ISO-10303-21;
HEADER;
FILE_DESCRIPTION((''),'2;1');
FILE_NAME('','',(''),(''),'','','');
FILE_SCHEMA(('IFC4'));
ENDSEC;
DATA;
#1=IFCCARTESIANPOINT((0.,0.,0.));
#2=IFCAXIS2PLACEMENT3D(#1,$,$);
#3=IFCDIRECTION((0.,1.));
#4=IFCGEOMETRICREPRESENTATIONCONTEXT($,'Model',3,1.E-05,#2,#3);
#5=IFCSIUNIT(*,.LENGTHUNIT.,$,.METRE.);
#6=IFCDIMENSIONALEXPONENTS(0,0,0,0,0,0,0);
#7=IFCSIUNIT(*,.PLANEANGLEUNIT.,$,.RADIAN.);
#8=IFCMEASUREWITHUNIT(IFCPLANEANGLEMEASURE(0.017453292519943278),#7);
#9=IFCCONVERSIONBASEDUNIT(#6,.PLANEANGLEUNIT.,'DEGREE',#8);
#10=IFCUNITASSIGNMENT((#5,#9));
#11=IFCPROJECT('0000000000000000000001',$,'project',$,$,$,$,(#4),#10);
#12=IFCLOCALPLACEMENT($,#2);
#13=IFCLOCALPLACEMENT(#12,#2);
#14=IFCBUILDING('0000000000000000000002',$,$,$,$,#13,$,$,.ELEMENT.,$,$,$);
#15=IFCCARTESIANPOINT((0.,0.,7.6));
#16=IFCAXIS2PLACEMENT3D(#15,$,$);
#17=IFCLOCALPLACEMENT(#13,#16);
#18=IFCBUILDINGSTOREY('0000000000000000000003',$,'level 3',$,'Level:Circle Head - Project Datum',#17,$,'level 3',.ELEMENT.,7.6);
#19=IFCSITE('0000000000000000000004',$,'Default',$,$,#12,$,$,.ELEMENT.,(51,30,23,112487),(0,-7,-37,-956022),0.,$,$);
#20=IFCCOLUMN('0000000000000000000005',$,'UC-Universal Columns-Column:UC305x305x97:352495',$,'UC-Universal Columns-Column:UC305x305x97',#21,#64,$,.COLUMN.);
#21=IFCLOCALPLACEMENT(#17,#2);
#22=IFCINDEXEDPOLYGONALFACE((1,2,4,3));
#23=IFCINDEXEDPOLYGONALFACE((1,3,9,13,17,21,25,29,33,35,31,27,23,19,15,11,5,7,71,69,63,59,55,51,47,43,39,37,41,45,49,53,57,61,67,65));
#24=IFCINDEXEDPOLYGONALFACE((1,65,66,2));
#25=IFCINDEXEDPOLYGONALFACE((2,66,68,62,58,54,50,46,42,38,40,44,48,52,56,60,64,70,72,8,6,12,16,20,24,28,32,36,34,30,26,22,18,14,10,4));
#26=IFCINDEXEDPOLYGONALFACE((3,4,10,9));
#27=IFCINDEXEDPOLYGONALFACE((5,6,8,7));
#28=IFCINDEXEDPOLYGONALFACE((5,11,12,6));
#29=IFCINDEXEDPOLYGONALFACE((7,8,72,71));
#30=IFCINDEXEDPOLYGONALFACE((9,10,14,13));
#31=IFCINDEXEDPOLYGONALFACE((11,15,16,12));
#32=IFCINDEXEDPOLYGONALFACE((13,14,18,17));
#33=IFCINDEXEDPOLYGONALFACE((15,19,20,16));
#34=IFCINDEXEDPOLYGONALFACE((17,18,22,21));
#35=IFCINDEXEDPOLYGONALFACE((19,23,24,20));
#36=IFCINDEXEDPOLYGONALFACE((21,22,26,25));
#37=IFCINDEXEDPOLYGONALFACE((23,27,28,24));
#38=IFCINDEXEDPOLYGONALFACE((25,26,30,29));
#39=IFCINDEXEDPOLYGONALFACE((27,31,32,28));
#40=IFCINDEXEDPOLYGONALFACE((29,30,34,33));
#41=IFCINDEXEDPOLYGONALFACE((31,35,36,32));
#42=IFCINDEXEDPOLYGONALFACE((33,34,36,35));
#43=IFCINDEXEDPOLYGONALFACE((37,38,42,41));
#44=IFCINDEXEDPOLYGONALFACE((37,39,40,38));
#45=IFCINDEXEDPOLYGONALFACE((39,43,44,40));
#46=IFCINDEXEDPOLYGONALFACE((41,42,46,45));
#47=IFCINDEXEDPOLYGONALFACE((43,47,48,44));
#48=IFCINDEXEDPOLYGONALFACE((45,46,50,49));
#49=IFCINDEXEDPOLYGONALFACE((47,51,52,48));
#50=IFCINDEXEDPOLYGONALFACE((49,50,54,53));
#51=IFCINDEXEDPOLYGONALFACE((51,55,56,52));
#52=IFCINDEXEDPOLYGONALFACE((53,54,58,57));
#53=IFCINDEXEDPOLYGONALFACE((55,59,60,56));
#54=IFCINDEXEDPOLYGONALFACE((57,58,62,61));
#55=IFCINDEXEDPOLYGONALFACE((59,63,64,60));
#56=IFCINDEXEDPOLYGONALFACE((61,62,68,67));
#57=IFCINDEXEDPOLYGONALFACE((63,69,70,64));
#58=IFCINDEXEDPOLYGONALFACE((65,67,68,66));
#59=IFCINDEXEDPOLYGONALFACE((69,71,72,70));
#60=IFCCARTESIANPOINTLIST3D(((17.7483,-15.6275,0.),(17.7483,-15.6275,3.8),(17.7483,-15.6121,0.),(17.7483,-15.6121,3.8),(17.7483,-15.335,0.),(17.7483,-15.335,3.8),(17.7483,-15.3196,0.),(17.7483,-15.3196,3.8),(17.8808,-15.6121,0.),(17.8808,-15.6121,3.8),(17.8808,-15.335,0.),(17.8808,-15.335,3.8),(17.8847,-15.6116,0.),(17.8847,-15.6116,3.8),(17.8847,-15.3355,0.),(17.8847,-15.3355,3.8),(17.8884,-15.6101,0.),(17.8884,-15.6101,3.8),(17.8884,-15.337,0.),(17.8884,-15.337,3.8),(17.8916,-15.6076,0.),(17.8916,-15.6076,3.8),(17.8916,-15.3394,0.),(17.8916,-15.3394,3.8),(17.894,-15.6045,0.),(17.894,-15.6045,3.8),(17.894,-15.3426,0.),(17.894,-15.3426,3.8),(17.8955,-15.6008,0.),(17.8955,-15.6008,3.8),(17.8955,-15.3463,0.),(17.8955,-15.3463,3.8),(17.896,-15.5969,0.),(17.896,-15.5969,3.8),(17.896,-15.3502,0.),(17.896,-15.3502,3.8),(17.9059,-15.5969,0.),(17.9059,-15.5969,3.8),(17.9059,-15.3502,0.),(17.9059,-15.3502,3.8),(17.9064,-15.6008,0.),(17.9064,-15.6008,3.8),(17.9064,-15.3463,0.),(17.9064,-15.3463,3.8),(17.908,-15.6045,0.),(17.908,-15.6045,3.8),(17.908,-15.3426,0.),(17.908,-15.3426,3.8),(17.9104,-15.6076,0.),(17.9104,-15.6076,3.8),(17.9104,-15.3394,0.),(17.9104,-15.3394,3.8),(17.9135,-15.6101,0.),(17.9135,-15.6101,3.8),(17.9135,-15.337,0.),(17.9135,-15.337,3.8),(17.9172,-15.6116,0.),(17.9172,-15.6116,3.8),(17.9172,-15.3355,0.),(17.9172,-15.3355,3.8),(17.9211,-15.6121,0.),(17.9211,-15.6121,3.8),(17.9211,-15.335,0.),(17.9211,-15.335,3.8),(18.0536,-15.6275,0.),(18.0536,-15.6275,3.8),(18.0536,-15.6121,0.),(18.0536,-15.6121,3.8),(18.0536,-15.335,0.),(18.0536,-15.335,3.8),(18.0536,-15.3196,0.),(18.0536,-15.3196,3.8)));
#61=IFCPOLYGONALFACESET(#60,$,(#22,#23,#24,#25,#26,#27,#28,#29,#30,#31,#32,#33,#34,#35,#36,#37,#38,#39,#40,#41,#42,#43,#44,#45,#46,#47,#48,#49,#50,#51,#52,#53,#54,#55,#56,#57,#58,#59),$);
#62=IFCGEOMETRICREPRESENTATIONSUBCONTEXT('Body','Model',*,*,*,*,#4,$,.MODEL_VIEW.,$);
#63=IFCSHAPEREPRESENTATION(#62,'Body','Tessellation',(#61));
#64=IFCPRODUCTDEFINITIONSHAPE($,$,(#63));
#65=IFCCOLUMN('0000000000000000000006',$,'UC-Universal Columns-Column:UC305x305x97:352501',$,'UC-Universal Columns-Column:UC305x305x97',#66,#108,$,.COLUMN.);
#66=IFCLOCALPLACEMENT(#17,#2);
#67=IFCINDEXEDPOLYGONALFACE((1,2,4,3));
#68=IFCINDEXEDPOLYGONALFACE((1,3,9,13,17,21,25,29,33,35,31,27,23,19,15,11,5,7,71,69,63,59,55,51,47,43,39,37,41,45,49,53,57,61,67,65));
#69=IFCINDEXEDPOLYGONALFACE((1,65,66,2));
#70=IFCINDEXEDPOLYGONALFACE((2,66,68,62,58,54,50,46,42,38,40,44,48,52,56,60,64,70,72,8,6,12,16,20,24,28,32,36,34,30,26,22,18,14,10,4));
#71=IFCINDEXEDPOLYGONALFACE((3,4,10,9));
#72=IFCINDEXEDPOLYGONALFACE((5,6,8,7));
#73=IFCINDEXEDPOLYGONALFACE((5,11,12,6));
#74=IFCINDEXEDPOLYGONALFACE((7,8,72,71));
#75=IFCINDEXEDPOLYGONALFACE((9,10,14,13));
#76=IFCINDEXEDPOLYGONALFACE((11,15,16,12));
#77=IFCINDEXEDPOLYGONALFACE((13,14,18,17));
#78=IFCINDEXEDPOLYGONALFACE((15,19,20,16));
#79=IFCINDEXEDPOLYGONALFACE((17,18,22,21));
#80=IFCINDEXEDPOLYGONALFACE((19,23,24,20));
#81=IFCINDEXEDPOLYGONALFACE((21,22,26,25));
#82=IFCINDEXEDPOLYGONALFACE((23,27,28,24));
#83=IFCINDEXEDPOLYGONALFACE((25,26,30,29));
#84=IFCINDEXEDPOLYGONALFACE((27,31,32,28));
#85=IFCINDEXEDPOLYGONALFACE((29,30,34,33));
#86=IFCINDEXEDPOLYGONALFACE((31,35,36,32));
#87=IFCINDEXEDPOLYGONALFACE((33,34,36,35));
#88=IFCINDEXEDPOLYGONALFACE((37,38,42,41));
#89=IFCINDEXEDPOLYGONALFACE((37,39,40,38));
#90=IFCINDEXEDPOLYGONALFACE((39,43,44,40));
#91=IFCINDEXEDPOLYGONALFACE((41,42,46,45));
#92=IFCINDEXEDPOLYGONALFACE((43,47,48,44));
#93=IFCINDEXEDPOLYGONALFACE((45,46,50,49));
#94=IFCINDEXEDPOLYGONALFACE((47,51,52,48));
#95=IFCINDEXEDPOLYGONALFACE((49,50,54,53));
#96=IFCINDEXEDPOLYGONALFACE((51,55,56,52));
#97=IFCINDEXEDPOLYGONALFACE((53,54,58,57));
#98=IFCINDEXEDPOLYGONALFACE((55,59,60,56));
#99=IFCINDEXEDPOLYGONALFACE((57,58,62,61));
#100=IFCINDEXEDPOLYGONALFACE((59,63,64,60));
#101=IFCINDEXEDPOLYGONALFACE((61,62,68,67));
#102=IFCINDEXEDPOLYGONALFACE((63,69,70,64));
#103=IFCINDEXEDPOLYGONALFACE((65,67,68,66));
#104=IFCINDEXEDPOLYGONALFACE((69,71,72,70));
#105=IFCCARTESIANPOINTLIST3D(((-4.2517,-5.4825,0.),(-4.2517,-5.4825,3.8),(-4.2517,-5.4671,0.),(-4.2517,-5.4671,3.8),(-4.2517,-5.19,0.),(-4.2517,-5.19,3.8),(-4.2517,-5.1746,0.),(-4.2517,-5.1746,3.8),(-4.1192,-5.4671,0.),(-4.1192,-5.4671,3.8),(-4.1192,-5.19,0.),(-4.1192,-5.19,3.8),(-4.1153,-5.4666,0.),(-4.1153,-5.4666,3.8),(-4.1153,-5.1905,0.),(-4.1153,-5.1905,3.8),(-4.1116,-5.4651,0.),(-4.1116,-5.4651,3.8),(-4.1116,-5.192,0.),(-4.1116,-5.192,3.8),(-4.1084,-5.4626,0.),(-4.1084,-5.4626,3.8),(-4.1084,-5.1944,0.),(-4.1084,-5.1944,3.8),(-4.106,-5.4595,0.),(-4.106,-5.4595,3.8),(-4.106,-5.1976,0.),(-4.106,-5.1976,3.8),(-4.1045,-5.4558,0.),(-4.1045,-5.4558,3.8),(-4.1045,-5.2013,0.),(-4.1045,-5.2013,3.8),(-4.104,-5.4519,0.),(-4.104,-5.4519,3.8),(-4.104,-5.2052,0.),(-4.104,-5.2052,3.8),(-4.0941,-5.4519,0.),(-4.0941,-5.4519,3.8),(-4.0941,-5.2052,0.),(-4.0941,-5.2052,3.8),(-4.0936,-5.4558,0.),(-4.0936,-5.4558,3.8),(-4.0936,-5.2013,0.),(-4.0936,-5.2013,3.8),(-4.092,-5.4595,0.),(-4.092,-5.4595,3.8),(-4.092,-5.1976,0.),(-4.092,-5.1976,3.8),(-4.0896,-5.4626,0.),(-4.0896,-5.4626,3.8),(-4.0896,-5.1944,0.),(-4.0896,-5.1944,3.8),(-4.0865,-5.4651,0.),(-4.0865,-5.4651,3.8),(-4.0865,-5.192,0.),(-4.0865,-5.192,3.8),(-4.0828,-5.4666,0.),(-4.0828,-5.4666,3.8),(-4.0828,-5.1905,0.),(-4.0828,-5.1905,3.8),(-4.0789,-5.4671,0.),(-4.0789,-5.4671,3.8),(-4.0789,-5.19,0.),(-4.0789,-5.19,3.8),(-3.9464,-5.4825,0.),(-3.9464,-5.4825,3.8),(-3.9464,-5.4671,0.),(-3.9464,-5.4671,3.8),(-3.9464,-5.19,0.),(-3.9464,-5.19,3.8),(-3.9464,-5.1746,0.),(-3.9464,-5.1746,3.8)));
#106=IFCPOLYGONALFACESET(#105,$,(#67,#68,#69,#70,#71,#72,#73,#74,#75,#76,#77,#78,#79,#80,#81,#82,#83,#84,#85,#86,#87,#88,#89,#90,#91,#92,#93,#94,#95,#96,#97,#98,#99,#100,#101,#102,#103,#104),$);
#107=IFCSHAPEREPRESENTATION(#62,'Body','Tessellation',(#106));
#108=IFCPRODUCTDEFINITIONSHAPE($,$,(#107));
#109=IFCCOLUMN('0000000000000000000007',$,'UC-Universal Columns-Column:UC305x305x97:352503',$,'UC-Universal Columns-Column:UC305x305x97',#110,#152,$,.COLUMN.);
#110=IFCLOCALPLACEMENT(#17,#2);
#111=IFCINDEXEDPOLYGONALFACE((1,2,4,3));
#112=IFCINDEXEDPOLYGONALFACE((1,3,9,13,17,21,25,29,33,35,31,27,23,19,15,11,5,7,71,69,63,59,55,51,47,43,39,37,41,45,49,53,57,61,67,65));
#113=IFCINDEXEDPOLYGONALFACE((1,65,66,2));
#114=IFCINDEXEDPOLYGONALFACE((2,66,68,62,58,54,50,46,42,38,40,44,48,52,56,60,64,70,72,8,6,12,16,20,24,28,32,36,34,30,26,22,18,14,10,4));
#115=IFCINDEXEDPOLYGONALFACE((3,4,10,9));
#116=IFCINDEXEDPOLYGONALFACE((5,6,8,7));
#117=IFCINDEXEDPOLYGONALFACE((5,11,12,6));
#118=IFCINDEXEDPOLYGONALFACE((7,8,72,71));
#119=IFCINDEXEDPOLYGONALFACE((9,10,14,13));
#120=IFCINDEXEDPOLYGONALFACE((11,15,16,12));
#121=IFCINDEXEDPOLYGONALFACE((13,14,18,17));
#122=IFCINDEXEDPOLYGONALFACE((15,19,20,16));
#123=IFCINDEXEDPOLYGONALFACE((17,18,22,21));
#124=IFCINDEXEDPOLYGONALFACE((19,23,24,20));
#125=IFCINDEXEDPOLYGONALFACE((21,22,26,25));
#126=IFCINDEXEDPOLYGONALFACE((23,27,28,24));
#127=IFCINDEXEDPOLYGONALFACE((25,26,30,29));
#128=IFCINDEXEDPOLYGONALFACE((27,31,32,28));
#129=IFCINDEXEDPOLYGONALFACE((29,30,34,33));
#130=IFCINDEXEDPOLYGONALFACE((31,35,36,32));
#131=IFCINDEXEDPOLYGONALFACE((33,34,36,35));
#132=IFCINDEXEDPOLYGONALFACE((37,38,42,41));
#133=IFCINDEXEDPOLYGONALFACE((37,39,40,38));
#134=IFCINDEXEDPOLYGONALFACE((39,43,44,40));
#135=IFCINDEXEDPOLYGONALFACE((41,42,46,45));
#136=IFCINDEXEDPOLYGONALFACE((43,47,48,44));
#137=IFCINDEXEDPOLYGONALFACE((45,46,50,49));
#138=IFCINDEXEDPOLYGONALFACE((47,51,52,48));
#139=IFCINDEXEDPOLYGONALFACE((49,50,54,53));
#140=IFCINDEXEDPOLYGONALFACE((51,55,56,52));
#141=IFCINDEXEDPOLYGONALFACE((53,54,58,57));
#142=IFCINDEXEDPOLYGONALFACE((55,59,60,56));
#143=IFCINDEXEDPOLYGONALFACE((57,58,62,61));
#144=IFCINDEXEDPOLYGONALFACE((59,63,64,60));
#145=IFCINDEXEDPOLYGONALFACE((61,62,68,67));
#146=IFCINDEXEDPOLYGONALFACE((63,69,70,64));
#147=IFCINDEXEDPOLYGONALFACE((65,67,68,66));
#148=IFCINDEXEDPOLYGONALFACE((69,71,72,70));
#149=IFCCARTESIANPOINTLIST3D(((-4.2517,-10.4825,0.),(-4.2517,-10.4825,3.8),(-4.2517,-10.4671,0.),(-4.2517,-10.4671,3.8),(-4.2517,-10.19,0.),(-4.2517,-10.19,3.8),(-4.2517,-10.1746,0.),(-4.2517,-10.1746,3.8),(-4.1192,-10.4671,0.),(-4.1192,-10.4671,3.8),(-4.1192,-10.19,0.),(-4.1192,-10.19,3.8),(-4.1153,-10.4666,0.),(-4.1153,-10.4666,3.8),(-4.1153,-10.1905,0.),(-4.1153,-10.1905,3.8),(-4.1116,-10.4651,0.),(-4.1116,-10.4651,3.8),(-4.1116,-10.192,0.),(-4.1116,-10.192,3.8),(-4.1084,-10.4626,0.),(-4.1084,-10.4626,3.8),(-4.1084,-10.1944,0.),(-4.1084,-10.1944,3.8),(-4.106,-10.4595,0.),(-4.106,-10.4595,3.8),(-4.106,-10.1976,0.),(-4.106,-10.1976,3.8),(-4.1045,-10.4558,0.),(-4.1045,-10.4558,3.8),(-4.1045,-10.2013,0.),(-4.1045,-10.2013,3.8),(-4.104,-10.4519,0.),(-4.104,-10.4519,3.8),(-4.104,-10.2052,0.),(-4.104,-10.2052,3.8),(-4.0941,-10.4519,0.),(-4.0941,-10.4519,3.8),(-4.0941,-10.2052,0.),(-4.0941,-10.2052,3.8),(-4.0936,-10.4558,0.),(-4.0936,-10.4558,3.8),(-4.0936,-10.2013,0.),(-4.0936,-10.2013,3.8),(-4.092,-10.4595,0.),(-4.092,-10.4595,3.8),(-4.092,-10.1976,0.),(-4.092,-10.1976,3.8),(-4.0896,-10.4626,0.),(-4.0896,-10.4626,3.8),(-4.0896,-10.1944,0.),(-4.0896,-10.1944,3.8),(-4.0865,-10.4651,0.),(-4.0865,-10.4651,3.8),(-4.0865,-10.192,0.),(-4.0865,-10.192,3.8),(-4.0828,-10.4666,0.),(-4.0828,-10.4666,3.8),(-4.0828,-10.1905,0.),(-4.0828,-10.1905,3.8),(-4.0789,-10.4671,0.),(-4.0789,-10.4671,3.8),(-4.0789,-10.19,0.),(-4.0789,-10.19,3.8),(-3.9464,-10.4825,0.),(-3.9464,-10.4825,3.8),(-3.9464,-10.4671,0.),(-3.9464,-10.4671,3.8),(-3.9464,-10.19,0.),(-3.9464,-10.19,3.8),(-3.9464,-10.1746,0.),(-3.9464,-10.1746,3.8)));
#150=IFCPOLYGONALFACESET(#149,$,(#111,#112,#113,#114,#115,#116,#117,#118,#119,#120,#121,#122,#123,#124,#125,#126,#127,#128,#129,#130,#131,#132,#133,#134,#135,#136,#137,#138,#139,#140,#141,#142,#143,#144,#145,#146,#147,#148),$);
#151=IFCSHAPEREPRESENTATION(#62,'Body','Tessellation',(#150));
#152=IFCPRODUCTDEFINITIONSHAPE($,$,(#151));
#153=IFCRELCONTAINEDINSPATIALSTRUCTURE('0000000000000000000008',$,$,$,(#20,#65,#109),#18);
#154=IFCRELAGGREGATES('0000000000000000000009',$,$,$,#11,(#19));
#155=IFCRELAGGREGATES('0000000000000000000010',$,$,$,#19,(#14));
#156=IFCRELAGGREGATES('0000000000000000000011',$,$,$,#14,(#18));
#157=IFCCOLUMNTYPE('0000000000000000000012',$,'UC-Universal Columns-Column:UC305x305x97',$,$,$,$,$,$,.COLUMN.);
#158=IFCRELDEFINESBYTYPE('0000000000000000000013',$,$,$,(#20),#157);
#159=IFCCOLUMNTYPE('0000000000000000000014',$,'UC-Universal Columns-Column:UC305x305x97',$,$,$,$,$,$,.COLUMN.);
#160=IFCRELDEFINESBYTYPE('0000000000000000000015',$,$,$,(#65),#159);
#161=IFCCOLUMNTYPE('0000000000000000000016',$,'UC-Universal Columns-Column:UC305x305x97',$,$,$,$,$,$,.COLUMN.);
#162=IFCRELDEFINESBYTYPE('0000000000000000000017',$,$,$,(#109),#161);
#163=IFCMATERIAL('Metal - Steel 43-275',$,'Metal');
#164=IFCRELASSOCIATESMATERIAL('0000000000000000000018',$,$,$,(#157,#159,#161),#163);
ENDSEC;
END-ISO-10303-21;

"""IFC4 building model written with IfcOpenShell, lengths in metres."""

from ifc_helpers import new_model, entity, si_unit, converted_unit, direction, frame, frame_2d, origin, origin_2d_with_axis, place, context, subcontext, project, spatial, i_section, extrude, source, transform, mapped, material, material_profile, profile_set, type_object, type_shapes, element, save


model = new_model("IFC4")

# Units and contexts
model_context = context("Model", 3, precision=1e-05, world=origin(), true_north=direction((0.0, 1.0)))
body_context = subcontext(model_context, "Body", "Model", "MODEL_VIEW")
ifc_project = project(units=[si_unit("LENGTHUNIT", "METRE"), converted_unit("PLANEANGLEUNIT", "DEGREE", entity("IfcPlaneAngleMeasure", 0.017453292519943278), si_unit("PLANEANGLEUNIT", "RADIAN"), dimensions=[0, 0, 0, 0, 0, 0, 0])], contexts=[model_context])

# Site, building, storey
site_placement = place(None, origin())
site = spatial("IfcSite", under=ifc_project, at=site_placement, Name="Default", CompositionType="ELEMENT", RefLatitude=(51, 30, 23, 112487), RefLongitude=(0, -7, -37, -956022), RefElevation=0.0)
building_placement = place(site_placement, origin())
building = spatial("IfcBuilding", under=site, at=building_placement, CompositionType="ELEMENT")
storey_placement = place(building_placement, frame((0.0, 0.0, 7.6)))
storey = spatial("IfcBuildingStorey", under=building, at=storey_placement, Name="level 3", ObjectType="Level:Circle Head - Project Datum", LongName="level 3", CompositionType="ELEMENT", Elevation=7.6)

# Columns
ifc_material_1 = material(Name="Metal - Steel 43-275", Category="Metal")
ifc_material_profile_1 = material_profile(ifc_material_1, i_section(OverallWidth=0.3053, OverallDepth=0.3079, WebThickness=0.0099, FlangeThickness=0.0154, FilletRadius=0.0152, at=frame_2d((0.0, 0.0), x_axis=(1.0, 0.0))), Name="UC305x305x97")
ifc_profile_set_1 = profile_set([ifc_material_profile_1], Name="UC305x305x97")
column_type_1 = type_object("IfcColumnType", Name="UC-Universal Columns-Column:UC305x305x97", PredefinedType="COLUMN", material=ifc_profile_set_1)
shared_shape_1 = source(origin(), body_context, "Body", "SweptSolid", [
    extrude(i_section(OverallWidth=0.3053, OverallDepth=0.3079, WebThickness=0.0099, FlangeThickness=0.0154, FilletRadius=0.0152, at=frame_2d((0.0, 0.0), x_axis=(1.0, 0.0))), frame((17.901, -15.4735, 7.6), z_axis=(0.0, 0.0, 1.0), x_axis=(-1.0, 0.0, 0.0)), (0.0, 0.0, 1.0), 3.8),
])
type_shapes(column_type_1, [shared_shape_1])
column_1_placement = place(storey_placement, frame((0.0, 0.0, -7.6)))
element("IfcColumn", 1, at=column_1_placement, inside=storey, type_object=column_type_1, Name="UC-Universal Columns-Column:UC305x305x97:352495", ObjectType="UC-Universal Columns-Column:UC305x305x97", PredefinedType="COLUMN", context=body_context, shape_type="MappedRepresentation", body=[
    mapped(shared_shape_1, transform((0.0, 0.0, 0.0), scale=1.0)),
])
column_type_2 = type_object("IfcColumnType", Name="UC-Universal Columns-Column:UC305x305x97", PredefinedType="COLUMN", material=ifc_profile_set_1)
shared_shape_2 = source(origin(), body_context, "Body", "SweptSolid", [
    extrude(i_section(OverallWidth=0.3053, OverallDepth=0.3079, WebThickness=0.0099, FlangeThickness=0.0154, FilletRadius=0.0152, at=frame_2d((0.0, 0.0), x_axis=(1.0, 0.0))), frame((-4.099, -5.3285, 7.6), z_axis=(0.0, 0.0, 1.0), x_axis=(-1.0, 0.0, 0.0)), (0.0, 0.0, 1.0), 3.8),
])
type_shapes(column_type_2, [shared_shape_2])
column_2_placement = place(storey_placement, frame((0.0, 0.0, -7.6)))
element("IfcColumn", 2, at=column_2_placement, inside=storey, type_object=column_type_2, Name="UC-Universal Columns-Column:UC305x305x97:352501", ObjectType="UC-Universal Columns-Column:UC305x305x97", PredefinedType="COLUMN", context=body_context, shape_type="MappedRepresentation", body=[
    mapped(shared_shape_2, transform((0.0, 0.0, 0.0), scale=1.0)),
])
column_type_3 = type_object("IfcColumnType", Name="UC-Universal Columns-Column:UC305x305x97", PredefinedType="COLUMN", material=ifc_profile_set_1)
shared_shape_3 = source(origin(), body_context, "Body", "SweptSolid", [
    extrude(i_section(OverallWidth=0.3053, OverallDepth=0.3079, WebThickness=0.0099, FlangeThickness=0.0154, FilletRadius=0.0152, at=origin_2d_with_axis()), frame((-4.099, -10.3285, 7.6), z_axis=(0.0, 0.0, 1.0), x_axis=(-1.0, 0.0, 0.0)), (0.0, 0.0, 1.0), 3.8),
])
type_shapes(column_type_3, [shared_shape_3])
column_3_placement = place(storey_placement, frame((0.0, 0.0, -7.6)))
element("IfcColumn", 3, at=column_3_placement, inside=storey, type_object=column_type_3, Name="UC-Universal Columns-Column:UC305x305x97:352503", ObjectType="UC-Universal Columns-Column:UC305x305x97", PredefinedType="COLUMN", context=body_context, shape_type="MappedRepresentation", body=[
    mapped(shared_shape_3, transform((0.0, 0.0, 0.0), scale=1.0)),
])

save(model, "model.ifc")
